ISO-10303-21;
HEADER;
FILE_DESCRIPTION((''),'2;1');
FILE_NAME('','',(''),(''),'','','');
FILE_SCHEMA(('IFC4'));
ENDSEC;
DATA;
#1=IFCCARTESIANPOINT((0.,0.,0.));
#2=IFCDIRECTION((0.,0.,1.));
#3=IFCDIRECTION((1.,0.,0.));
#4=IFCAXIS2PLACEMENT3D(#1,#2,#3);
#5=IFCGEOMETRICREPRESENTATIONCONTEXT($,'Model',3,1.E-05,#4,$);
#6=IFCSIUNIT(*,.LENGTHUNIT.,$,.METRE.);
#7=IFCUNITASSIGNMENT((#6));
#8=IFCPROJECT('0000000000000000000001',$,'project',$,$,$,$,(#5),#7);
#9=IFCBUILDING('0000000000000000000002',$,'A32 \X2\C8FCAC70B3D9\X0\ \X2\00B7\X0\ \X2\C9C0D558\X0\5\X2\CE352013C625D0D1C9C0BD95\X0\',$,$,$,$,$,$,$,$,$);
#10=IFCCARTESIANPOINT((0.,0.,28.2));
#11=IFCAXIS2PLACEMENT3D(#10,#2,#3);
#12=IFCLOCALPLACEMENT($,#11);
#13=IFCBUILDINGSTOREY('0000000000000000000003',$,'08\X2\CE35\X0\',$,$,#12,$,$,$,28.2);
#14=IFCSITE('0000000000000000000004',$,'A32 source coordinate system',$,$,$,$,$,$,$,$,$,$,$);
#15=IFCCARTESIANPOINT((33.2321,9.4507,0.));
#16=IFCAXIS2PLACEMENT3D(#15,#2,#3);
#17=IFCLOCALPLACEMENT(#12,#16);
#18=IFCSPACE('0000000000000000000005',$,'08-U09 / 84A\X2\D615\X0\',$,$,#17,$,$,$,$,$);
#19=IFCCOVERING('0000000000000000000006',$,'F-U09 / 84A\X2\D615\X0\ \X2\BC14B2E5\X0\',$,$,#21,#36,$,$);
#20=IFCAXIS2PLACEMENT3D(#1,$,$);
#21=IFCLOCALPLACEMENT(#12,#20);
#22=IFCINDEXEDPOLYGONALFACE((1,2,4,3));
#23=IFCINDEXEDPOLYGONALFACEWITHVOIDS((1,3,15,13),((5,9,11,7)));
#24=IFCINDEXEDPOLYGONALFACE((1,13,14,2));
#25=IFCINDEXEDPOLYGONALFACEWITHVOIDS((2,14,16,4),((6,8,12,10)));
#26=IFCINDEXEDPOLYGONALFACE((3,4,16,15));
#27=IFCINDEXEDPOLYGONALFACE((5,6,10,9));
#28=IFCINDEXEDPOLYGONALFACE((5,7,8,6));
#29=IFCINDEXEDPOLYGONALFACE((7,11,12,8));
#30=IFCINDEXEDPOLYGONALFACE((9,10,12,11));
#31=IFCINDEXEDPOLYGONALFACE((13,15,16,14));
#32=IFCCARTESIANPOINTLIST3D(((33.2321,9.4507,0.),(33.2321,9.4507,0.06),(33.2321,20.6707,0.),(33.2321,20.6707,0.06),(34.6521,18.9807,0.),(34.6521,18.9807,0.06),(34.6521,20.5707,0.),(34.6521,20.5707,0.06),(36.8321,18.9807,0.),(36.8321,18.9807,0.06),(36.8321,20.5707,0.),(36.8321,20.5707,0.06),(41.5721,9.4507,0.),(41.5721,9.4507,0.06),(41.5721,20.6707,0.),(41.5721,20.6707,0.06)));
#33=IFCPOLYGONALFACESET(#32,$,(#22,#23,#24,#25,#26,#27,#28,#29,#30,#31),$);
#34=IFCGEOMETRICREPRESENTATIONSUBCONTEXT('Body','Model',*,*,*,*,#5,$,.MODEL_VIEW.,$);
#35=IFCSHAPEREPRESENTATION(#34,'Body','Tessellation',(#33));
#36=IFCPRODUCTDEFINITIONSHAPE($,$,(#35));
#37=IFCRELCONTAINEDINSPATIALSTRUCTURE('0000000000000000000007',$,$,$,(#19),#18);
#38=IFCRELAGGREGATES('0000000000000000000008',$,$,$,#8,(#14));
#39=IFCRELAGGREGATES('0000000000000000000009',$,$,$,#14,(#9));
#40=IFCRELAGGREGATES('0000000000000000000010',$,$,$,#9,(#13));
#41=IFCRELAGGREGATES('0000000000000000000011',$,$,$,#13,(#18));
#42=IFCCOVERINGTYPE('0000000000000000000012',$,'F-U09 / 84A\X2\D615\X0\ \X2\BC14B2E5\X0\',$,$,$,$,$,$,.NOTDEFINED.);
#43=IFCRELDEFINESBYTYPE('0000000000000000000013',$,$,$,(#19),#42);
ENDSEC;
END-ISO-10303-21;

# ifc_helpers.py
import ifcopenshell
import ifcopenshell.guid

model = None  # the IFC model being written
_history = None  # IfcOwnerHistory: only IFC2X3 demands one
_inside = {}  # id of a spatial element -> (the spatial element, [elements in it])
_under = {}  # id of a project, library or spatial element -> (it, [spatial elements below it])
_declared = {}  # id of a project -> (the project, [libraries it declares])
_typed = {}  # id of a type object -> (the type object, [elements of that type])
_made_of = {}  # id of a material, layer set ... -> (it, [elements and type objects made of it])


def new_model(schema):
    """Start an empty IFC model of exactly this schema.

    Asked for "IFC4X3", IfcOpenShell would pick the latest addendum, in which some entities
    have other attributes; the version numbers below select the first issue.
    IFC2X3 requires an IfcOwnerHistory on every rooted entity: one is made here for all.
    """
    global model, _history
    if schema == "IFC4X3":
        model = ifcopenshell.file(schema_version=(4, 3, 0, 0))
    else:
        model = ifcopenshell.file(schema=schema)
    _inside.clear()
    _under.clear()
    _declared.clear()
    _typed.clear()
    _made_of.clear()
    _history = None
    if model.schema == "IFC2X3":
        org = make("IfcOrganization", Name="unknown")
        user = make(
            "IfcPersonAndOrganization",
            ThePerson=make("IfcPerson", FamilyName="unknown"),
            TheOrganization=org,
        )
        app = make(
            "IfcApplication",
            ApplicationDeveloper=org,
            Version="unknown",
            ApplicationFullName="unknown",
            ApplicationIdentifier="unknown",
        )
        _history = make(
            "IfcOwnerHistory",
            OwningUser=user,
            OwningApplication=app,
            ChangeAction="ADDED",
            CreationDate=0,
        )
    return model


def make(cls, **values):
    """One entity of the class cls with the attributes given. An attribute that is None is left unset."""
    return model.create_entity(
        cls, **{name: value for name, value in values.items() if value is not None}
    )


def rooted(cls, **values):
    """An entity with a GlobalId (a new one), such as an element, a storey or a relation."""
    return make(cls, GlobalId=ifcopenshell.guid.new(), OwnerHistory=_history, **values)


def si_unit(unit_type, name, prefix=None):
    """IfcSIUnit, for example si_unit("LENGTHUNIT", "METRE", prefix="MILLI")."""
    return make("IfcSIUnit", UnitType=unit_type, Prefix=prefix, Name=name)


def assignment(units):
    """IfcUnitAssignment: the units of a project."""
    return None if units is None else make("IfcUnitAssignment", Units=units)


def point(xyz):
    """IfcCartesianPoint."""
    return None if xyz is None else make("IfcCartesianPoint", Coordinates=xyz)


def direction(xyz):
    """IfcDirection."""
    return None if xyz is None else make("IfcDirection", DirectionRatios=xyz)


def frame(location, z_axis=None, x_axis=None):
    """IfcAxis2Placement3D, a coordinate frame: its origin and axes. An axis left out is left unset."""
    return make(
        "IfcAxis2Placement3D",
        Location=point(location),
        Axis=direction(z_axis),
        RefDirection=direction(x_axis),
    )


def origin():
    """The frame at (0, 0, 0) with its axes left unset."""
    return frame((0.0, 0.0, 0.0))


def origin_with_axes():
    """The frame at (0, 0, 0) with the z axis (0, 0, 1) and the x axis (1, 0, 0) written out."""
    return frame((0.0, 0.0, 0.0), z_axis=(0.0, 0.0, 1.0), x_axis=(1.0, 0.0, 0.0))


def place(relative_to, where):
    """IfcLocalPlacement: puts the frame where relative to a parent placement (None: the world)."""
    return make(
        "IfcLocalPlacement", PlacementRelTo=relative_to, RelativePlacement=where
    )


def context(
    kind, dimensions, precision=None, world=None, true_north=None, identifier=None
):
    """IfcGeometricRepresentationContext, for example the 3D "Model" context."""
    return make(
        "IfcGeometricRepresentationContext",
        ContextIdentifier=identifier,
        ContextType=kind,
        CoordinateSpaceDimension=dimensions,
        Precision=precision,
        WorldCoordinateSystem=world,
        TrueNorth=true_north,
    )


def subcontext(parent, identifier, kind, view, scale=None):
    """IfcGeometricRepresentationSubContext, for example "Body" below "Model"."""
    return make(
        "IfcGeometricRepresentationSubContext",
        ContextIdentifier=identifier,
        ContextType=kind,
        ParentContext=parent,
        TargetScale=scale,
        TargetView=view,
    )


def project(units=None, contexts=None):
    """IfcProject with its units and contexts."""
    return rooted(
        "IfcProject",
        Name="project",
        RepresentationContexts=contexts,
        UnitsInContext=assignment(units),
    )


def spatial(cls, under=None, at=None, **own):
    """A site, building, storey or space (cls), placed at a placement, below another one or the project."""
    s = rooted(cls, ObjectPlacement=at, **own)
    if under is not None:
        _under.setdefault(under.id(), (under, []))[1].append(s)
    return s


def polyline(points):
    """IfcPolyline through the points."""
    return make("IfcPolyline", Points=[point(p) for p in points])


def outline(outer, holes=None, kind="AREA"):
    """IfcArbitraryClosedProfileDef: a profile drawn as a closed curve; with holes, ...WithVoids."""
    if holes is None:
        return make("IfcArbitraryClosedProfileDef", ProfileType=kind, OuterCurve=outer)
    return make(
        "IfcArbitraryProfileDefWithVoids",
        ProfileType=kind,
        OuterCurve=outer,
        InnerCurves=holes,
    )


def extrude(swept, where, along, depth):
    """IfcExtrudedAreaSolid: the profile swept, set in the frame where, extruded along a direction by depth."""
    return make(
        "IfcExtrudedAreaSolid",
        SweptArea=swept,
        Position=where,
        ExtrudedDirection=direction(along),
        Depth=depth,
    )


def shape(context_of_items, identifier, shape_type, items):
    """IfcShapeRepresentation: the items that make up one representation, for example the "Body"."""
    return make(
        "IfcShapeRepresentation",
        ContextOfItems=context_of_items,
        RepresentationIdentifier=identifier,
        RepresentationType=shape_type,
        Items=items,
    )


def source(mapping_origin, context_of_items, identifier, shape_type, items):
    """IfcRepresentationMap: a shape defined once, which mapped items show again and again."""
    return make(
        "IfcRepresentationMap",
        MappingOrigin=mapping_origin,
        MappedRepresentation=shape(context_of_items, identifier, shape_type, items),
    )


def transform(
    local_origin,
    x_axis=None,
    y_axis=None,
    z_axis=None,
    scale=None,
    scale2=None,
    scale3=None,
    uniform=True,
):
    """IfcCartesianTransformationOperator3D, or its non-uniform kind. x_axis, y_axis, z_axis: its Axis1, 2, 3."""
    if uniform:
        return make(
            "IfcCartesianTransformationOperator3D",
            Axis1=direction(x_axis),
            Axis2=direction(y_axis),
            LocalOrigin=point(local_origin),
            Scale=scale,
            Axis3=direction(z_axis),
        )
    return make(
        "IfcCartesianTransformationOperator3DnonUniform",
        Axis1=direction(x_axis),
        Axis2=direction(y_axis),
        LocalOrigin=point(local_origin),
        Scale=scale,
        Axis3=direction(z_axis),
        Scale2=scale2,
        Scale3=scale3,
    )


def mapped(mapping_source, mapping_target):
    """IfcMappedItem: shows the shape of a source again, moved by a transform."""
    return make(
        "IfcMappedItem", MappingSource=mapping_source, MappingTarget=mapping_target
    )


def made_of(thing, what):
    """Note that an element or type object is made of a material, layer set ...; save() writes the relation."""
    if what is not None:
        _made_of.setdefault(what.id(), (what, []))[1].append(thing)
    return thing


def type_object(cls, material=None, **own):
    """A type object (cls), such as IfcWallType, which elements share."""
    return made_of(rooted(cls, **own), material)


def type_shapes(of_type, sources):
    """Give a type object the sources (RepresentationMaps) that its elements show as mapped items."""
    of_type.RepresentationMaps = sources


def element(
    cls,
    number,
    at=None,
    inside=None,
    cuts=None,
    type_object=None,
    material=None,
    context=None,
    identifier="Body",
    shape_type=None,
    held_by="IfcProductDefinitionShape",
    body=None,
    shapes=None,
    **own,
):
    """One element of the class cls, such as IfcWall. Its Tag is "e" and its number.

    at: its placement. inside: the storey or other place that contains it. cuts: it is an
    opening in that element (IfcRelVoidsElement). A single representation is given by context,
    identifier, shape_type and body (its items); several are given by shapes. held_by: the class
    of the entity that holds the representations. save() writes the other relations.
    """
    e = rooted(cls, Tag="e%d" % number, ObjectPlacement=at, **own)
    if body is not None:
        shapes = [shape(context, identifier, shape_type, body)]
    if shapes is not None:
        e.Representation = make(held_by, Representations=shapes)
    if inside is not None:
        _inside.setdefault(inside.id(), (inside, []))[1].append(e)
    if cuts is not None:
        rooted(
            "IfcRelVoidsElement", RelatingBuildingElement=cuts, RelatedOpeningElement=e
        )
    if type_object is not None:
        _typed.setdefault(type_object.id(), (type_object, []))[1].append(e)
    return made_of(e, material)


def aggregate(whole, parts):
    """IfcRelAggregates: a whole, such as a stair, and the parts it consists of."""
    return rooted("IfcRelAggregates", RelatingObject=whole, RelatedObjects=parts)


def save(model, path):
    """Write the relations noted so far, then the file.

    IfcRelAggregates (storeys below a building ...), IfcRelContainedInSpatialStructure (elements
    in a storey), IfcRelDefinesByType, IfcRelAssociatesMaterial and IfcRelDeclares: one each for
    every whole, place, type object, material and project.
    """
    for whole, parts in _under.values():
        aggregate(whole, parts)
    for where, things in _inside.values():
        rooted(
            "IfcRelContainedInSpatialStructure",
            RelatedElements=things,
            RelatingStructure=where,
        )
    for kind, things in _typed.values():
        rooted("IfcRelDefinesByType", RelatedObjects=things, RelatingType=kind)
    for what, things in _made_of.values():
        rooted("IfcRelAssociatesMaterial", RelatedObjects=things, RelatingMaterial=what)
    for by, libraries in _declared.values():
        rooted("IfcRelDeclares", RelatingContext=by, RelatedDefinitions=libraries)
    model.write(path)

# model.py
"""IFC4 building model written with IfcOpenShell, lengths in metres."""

from ifc_helpers import new_model, si_unit, frame, origin, origin_with_axes, place, context, subcontext, project, spatial, polyline, outline, extrude, source, transform, mapped, type_object, type_shapes, element, save


model = new_model("IFC4")

# Units and contexts
model_context = context("Model", 3, precision=1e-05, world=origin_with_axes())
body_context = subcontext(model_context, "Body", "Model", "MODEL_VIEW")
ifc_project = project(units=[si_unit("LENGTHUNIT", "METRE")], contexts=[model_context])

# Site, building, storey, space
storey_placement = place(None, frame((0.0, 0.0, 28.2), z_axis=(0.0, 0.0, 1.0), x_axis=(1.0, 0.0, 0.0)))
space_placement = place(storey_placement, frame((33.2321, 9.4507, 0.0), z_axis=(0.0, 0.0, 1.0), x_axis=(1.0, 0.0, 0.0)))
site = spatial("IfcSite", under=ifc_project, Name="A32 source coordinate system")
building = spatial("IfcBuilding", under=site, Name="A32 주거동 · 지하5층–옥탑지붕")
storey = spatial("IfcBuildingStorey", under=building, at=storey_placement, Name="08층", Elevation=28.2)
space = spatial("IfcSpace", under=storey, at=space_placement, Name="08-U09 / 84A형")

# Covering
covering_type_1 = type_object("IfcCoveringType", Name="F-U09 / 84A형 바닥", PredefinedType="NOTDEFINED")
shared_shape_1 = source(origin(), body_context, "Body", "SweptSolid", [
    extrude(outline(polyline([(0.0, 0.0), (0.0, 11.22), (8.34, 11.22), (8.34, 0.0), (0.0, 0.0)]), holes=[polyline([(1.42, 11.12), (1.42, 9.53), (3.6, 9.53), (3.6, 11.12), (1.42, 11.12)])]), origin(), (0.0, 0.0, 1.0), 0.06),
])
type_shapes(covering_type_1, [shared_shape_1])
covering_1_placement = place(space_placement, origin_with_axes())
element("IfcCovering", 1, at=covering_1_placement, inside=space, type_object=covering_type_1, Name="F-U09 / 84A형 바닥", context=body_context, shape_type="MappedRepresentation", body=[
    mapped(shared_shape_1, transform((0.0, 0.0, 0.0), scale=1.0)),
])

save(model, "model.ifc")
